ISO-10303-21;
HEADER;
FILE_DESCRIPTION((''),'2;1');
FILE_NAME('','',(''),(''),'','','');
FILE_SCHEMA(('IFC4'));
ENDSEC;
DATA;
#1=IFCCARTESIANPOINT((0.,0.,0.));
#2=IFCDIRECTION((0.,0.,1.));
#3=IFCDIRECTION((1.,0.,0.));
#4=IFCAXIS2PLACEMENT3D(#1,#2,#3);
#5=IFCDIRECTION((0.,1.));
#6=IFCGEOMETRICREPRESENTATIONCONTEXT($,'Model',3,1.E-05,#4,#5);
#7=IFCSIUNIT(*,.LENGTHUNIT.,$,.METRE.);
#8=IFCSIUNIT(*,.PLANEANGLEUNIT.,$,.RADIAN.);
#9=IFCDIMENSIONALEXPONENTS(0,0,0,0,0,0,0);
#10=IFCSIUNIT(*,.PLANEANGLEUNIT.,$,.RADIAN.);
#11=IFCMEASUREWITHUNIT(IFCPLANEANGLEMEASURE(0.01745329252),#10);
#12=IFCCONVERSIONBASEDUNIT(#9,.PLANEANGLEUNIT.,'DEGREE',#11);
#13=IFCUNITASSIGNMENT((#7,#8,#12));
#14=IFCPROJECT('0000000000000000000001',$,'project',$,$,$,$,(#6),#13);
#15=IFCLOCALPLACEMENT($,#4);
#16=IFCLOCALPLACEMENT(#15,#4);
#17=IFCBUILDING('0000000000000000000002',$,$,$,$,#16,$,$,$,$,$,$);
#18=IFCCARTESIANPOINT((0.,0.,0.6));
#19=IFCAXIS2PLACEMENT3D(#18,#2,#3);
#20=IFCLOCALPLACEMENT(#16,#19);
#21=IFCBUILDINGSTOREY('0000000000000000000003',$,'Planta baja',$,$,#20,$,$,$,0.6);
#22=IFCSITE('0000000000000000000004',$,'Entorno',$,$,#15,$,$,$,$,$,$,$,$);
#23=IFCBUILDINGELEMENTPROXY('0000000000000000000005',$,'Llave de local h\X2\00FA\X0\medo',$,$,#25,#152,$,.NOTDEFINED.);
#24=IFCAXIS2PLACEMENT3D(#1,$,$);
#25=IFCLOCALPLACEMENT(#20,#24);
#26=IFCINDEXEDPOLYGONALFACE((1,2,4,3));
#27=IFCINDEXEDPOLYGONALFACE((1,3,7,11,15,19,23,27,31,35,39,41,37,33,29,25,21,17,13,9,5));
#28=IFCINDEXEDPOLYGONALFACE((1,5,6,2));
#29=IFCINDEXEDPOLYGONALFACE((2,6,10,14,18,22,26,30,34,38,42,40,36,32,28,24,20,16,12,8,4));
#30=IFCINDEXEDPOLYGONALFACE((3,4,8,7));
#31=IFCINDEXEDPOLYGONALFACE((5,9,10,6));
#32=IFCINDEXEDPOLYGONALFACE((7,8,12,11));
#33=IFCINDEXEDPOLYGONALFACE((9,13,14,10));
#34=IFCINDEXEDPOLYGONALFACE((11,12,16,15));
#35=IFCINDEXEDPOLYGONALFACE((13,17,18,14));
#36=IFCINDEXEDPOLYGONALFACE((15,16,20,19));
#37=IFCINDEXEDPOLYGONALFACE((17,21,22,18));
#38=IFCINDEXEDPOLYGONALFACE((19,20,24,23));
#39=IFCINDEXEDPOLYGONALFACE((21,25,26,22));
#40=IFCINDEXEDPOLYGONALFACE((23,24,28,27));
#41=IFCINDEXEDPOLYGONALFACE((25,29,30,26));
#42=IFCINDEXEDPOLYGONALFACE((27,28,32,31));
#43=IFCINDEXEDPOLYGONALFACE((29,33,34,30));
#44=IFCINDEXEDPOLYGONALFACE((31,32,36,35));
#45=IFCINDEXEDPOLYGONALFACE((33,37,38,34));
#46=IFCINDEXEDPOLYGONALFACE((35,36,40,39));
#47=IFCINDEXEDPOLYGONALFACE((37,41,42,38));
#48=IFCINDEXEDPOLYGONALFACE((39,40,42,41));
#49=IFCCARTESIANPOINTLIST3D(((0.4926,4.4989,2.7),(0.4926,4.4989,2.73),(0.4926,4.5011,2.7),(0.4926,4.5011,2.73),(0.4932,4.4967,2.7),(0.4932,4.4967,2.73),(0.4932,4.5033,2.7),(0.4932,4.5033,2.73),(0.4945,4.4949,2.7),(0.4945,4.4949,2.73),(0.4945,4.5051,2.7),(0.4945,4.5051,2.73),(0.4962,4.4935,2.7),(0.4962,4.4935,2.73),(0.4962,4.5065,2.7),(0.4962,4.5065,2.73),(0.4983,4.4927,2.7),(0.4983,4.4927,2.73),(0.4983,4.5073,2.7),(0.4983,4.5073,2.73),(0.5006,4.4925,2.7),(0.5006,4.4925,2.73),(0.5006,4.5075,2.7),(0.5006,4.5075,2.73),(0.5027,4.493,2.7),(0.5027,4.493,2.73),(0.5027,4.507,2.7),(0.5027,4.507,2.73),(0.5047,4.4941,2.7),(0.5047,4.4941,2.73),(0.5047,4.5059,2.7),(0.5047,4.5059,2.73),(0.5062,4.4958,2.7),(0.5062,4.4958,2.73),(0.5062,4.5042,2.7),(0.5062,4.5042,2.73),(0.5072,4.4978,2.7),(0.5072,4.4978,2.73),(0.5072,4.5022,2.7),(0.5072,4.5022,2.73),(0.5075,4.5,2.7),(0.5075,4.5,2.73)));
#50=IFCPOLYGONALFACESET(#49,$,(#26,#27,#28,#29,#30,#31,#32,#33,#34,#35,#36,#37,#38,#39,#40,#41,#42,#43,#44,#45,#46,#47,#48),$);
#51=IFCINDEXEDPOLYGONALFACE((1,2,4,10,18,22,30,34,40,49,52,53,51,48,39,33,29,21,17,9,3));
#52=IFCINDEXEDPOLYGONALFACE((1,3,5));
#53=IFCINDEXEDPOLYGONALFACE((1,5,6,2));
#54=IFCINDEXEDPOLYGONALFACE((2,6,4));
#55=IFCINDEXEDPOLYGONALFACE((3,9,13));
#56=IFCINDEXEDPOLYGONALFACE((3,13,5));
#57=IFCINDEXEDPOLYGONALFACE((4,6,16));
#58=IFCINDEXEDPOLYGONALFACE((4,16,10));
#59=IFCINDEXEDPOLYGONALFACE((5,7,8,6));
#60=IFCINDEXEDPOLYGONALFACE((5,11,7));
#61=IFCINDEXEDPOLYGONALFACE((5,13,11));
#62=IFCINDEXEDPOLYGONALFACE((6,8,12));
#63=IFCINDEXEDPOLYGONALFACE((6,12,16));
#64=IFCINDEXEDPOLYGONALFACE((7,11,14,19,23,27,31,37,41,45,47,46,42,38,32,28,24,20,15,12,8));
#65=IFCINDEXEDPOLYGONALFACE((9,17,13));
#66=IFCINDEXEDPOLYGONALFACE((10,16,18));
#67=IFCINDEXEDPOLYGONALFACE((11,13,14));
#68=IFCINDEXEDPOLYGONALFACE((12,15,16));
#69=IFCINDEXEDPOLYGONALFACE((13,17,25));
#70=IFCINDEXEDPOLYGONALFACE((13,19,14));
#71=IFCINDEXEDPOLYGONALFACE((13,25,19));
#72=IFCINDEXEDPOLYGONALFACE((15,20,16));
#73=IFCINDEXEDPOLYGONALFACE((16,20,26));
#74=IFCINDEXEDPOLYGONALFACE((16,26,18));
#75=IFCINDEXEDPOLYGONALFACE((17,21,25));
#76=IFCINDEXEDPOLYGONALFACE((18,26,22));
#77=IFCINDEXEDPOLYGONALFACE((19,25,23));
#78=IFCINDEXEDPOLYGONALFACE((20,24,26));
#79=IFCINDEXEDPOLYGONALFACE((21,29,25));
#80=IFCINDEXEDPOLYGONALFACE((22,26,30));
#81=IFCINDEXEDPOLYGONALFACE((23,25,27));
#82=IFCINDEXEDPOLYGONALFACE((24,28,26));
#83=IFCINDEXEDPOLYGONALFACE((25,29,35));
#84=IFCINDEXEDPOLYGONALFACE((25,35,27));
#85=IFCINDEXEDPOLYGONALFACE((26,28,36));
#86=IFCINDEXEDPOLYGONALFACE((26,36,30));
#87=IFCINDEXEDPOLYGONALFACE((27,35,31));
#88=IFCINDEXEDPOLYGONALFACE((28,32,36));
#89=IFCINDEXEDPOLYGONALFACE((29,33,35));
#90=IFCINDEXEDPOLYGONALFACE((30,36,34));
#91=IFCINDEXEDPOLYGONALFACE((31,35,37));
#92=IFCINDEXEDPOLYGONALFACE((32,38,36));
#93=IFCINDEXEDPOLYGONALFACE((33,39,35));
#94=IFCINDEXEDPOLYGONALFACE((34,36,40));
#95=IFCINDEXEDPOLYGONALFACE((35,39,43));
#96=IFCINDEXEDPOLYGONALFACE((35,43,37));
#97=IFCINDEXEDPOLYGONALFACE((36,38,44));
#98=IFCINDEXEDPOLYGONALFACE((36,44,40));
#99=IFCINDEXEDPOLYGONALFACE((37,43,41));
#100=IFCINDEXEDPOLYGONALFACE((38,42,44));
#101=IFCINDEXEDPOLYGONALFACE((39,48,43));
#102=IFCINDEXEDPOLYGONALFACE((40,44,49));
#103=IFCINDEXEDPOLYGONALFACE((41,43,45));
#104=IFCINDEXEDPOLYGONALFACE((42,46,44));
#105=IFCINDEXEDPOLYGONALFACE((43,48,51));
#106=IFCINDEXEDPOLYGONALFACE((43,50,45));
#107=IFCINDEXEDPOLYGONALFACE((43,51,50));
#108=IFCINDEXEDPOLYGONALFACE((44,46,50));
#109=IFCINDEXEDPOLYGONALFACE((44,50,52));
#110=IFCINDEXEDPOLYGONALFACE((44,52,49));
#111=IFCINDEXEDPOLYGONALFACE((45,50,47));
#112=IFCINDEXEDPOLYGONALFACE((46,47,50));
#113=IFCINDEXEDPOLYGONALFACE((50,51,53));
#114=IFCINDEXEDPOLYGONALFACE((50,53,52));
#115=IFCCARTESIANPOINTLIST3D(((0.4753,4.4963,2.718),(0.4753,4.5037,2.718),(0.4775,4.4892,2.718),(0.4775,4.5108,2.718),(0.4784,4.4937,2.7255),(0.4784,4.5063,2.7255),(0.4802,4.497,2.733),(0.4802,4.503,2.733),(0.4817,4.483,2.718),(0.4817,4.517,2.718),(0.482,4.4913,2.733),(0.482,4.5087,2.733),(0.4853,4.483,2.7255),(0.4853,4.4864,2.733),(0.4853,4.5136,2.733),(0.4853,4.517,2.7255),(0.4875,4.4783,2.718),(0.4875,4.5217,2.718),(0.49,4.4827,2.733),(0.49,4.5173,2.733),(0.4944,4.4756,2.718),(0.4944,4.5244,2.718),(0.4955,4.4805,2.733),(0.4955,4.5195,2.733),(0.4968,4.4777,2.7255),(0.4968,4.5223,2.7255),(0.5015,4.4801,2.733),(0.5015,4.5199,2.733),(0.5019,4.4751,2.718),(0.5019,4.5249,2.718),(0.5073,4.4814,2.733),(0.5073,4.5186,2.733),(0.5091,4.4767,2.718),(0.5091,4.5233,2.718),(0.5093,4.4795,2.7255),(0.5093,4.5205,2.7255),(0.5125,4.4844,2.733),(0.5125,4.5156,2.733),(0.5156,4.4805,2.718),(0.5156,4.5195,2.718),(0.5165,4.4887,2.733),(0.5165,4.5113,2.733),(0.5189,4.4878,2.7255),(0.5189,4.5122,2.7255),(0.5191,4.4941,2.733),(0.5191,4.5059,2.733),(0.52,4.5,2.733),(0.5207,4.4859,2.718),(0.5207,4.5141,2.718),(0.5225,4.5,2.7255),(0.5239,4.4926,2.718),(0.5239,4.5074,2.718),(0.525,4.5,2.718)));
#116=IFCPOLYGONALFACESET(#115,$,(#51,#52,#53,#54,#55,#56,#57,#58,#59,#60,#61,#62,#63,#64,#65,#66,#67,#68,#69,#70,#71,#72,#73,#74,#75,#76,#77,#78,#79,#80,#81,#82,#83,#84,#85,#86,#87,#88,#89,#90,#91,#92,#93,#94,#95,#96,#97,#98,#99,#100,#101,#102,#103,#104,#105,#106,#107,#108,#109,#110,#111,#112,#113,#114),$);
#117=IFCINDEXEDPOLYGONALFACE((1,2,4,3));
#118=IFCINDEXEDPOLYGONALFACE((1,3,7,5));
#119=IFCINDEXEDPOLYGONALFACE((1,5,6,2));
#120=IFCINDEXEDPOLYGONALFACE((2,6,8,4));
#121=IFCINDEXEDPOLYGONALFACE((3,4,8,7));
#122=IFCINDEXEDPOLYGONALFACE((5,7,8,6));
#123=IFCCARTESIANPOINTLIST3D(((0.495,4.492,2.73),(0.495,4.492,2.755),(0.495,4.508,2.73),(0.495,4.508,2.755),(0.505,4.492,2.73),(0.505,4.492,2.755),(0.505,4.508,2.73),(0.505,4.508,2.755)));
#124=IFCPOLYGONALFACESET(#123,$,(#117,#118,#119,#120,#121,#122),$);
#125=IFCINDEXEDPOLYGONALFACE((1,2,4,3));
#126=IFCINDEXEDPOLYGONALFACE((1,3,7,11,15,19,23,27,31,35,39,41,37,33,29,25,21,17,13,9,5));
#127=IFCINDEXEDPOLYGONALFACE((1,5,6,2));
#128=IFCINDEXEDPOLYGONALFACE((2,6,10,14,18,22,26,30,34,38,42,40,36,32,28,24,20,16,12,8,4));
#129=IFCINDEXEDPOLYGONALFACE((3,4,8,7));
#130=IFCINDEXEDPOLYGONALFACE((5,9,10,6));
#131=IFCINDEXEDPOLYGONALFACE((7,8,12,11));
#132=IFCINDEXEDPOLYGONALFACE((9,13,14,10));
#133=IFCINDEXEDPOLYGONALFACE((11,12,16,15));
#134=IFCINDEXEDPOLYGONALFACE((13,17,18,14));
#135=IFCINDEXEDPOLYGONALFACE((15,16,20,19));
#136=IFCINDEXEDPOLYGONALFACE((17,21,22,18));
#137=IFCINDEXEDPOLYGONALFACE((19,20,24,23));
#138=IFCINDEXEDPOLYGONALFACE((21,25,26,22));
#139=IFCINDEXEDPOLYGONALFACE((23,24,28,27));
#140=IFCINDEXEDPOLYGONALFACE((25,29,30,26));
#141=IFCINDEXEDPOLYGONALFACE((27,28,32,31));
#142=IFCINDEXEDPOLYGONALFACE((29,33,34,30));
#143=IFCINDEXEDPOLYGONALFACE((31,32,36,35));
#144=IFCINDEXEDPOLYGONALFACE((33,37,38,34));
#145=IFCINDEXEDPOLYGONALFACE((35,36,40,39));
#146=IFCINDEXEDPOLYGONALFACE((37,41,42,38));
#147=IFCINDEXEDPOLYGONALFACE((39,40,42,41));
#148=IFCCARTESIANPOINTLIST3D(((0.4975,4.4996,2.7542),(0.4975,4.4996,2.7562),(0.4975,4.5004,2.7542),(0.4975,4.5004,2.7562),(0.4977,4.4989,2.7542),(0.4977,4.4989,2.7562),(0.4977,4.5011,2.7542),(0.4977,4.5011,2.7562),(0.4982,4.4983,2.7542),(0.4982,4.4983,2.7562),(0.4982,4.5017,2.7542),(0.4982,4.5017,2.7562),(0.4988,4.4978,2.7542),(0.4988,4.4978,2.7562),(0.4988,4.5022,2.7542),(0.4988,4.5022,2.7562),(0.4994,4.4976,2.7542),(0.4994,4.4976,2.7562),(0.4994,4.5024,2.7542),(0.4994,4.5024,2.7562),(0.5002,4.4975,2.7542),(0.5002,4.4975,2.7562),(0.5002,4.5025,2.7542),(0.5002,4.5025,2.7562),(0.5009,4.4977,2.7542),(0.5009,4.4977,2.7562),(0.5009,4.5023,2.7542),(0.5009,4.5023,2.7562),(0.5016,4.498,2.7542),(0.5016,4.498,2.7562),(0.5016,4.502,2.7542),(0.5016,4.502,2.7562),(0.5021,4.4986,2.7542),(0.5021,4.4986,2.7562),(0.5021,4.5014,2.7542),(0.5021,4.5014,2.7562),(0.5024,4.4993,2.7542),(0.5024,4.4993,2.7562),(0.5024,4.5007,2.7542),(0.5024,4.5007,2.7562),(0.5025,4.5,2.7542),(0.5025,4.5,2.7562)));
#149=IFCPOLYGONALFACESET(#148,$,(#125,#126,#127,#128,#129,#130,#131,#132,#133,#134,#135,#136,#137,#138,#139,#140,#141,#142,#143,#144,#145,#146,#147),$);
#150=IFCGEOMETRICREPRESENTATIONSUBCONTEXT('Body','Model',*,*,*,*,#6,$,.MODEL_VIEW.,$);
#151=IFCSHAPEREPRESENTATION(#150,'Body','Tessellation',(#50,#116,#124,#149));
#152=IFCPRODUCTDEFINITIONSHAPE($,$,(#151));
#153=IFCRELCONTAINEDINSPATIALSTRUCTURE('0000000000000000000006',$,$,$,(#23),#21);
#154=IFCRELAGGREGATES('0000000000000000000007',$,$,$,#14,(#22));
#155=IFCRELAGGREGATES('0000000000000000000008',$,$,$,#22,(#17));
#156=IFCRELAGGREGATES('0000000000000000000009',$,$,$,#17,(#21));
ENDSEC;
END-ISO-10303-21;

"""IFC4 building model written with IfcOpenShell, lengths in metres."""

from ifc_helpers import new_model, entity, si_unit, converted_unit, direction, frame, origin_with_axes, place, context, subcontext, project, spatial, polyline, outline, extrude, element, save


model = new_model("IFC4")

# Units and contexts
model_context = context("Model", 3, precision=1e-05, world=origin_with_axes(), true_north=direction((0.0, 1.0)))
body_context = subcontext(model_context, "Body", "Model", "MODEL_VIEW")
ifc_project = project(units=[si_unit("LENGTHUNIT", "METRE"), si_unit("PLANEANGLEUNIT", "RADIAN"), converted_unit("PLANEANGLEUNIT", "DEGREE", entity("IfcPlaneAngleMeasure", 0.01745329252), si_unit("PLANEANGLEUNIT", "RADIAN"), dimensions=[0, 0, 0, 0, 0, 0, 0])], contexts=[model_context])

# Site, building, storey
site_placement = place(None, origin_with_axes())
site = spatial("IfcSite", under=ifc_project, at=site_placement, Name="Entorno")
building_placement = place(site_placement, origin_with_axes())
building = spatial("IfcBuilding", under=site, at=building_placement)
storey_placement = place(building_placement, frame((0.0, 0.0, 0.6), z_axis=(0.0, 0.0, 1.0), x_axis=(1.0, 0.0, 0.0)))
storey = spatial("IfcBuildingStorey", under=building, at=storey_placement, Name="Planta baja", Elevation=0.6)

# Building element proxy
proxy_1_placement = place(storey_placement, frame((0.0, 0.0, -0.6), z_axis=(0.0, 0.0, 1.0), x_axis=(1.0, 0.0, 0.0)))
ifc_direction_1 = entity("IfcDirection", [0.0, 0.0, 1.0])
ifc_direction_2 = entity("IfcDirection", [0.0, 0.0, 1.0])
ifc_direction_3 = entity("IfcDirection", [0.0, 0.0, 1.0])
element("IfcBuildingElementProxy", 1, at=proxy_1_placement, inside=storey, Name="Llave de local húmedo", PredefinedType="NOTDEFINED", context=body_context, shape_type="Brep", body=[
    entity("IfcExtrudedAreaSolidTapered", entity("IfcCircleProfileDef", "AREA", None, entity("IfcAxis2Placement2D", entity("IfcCartesianPoint", [0.0, 0.0]), entity("IfcDirection", [1.0, 0.0])), 0.0075), entity("IfcAxis2Placement3D", entity("IfcCartesianPoint", [0.5, 4.5, 3.3]), ifc_direction_1, entity("IfcDirection", [1.0, 0.0, 0.0])), ifc_direction_1, 0.03, entity("IfcCircleProfileDef", "AREA", None, entity("IfcAxis2Placement2D", entity("IfcCartesianPoint", [0.0, 0.0]), entity("IfcDirection", [1.0, 0.0])), 0.0075)),
    entity("IfcExtrudedAreaSolidTapered", entity("IfcCircleProfileDef", "AREA", None, entity("IfcAxis2Placement2D", entity("IfcCartesianPoint", [0.0, 0.0]), entity("IfcDirection", [1.0, 0.0])), 0.025), entity("IfcAxis2Placement3D", entity("IfcCartesianPoint", [0.5, 4.5, 3.318]), ifc_direction_2, entity("IfcDirection", [1.0, 0.0, 0.0])), ifc_direction_2, 0.015, entity("IfcCircleProfileDef", "AREA", None, entity("IfcAxis2Placement2D", entity("IfcCartesianPoint", [0.0, 0.0]), entity("IfcDirection", [1.0, 0.0])), 0.02)),
    extrude(outline(polyline([(0.005, -0.008), (0.005, 0.008), (-0.005, 0.008), (-0.005, -0.008), (0.005, -0.008)])), frame((0.5, 4.5, 3.33), z_axis=(0.0, 0.0, 1.0), x_axis=(1.0, 0.0, 0.0)), (0.0, 0.0, 1.0), 0.025),
    entity("IfcExtrudedAreaSolidTapered", entity("IfcCircleProfileDef", "AREA", None, entity("IfcAxis2Placement2D", entity("IfcCartesianPoint", [0.0, 0.0]), entity("IfcDirection", [1.0, 0.0])), 0.0025), entity("IfcAxis2Placement3D", entity("IfcCartesianPoint", [0.5, 4.5, 3.3542]), ifc_direction_3, entity("IfcDirection", [1.0, 0.0, 0.0])), ifc_direction_3, 0.002, entity("IfcCircleProfileDef", "AREA", None, entity("IfcAxis2Placement2D", entity("IfcCartesianPoint", [0.0, 0.0]), entity("IfcDirection", [1.0, 0.0])), 0.0025)),
])

save(model, "model.ifc")
